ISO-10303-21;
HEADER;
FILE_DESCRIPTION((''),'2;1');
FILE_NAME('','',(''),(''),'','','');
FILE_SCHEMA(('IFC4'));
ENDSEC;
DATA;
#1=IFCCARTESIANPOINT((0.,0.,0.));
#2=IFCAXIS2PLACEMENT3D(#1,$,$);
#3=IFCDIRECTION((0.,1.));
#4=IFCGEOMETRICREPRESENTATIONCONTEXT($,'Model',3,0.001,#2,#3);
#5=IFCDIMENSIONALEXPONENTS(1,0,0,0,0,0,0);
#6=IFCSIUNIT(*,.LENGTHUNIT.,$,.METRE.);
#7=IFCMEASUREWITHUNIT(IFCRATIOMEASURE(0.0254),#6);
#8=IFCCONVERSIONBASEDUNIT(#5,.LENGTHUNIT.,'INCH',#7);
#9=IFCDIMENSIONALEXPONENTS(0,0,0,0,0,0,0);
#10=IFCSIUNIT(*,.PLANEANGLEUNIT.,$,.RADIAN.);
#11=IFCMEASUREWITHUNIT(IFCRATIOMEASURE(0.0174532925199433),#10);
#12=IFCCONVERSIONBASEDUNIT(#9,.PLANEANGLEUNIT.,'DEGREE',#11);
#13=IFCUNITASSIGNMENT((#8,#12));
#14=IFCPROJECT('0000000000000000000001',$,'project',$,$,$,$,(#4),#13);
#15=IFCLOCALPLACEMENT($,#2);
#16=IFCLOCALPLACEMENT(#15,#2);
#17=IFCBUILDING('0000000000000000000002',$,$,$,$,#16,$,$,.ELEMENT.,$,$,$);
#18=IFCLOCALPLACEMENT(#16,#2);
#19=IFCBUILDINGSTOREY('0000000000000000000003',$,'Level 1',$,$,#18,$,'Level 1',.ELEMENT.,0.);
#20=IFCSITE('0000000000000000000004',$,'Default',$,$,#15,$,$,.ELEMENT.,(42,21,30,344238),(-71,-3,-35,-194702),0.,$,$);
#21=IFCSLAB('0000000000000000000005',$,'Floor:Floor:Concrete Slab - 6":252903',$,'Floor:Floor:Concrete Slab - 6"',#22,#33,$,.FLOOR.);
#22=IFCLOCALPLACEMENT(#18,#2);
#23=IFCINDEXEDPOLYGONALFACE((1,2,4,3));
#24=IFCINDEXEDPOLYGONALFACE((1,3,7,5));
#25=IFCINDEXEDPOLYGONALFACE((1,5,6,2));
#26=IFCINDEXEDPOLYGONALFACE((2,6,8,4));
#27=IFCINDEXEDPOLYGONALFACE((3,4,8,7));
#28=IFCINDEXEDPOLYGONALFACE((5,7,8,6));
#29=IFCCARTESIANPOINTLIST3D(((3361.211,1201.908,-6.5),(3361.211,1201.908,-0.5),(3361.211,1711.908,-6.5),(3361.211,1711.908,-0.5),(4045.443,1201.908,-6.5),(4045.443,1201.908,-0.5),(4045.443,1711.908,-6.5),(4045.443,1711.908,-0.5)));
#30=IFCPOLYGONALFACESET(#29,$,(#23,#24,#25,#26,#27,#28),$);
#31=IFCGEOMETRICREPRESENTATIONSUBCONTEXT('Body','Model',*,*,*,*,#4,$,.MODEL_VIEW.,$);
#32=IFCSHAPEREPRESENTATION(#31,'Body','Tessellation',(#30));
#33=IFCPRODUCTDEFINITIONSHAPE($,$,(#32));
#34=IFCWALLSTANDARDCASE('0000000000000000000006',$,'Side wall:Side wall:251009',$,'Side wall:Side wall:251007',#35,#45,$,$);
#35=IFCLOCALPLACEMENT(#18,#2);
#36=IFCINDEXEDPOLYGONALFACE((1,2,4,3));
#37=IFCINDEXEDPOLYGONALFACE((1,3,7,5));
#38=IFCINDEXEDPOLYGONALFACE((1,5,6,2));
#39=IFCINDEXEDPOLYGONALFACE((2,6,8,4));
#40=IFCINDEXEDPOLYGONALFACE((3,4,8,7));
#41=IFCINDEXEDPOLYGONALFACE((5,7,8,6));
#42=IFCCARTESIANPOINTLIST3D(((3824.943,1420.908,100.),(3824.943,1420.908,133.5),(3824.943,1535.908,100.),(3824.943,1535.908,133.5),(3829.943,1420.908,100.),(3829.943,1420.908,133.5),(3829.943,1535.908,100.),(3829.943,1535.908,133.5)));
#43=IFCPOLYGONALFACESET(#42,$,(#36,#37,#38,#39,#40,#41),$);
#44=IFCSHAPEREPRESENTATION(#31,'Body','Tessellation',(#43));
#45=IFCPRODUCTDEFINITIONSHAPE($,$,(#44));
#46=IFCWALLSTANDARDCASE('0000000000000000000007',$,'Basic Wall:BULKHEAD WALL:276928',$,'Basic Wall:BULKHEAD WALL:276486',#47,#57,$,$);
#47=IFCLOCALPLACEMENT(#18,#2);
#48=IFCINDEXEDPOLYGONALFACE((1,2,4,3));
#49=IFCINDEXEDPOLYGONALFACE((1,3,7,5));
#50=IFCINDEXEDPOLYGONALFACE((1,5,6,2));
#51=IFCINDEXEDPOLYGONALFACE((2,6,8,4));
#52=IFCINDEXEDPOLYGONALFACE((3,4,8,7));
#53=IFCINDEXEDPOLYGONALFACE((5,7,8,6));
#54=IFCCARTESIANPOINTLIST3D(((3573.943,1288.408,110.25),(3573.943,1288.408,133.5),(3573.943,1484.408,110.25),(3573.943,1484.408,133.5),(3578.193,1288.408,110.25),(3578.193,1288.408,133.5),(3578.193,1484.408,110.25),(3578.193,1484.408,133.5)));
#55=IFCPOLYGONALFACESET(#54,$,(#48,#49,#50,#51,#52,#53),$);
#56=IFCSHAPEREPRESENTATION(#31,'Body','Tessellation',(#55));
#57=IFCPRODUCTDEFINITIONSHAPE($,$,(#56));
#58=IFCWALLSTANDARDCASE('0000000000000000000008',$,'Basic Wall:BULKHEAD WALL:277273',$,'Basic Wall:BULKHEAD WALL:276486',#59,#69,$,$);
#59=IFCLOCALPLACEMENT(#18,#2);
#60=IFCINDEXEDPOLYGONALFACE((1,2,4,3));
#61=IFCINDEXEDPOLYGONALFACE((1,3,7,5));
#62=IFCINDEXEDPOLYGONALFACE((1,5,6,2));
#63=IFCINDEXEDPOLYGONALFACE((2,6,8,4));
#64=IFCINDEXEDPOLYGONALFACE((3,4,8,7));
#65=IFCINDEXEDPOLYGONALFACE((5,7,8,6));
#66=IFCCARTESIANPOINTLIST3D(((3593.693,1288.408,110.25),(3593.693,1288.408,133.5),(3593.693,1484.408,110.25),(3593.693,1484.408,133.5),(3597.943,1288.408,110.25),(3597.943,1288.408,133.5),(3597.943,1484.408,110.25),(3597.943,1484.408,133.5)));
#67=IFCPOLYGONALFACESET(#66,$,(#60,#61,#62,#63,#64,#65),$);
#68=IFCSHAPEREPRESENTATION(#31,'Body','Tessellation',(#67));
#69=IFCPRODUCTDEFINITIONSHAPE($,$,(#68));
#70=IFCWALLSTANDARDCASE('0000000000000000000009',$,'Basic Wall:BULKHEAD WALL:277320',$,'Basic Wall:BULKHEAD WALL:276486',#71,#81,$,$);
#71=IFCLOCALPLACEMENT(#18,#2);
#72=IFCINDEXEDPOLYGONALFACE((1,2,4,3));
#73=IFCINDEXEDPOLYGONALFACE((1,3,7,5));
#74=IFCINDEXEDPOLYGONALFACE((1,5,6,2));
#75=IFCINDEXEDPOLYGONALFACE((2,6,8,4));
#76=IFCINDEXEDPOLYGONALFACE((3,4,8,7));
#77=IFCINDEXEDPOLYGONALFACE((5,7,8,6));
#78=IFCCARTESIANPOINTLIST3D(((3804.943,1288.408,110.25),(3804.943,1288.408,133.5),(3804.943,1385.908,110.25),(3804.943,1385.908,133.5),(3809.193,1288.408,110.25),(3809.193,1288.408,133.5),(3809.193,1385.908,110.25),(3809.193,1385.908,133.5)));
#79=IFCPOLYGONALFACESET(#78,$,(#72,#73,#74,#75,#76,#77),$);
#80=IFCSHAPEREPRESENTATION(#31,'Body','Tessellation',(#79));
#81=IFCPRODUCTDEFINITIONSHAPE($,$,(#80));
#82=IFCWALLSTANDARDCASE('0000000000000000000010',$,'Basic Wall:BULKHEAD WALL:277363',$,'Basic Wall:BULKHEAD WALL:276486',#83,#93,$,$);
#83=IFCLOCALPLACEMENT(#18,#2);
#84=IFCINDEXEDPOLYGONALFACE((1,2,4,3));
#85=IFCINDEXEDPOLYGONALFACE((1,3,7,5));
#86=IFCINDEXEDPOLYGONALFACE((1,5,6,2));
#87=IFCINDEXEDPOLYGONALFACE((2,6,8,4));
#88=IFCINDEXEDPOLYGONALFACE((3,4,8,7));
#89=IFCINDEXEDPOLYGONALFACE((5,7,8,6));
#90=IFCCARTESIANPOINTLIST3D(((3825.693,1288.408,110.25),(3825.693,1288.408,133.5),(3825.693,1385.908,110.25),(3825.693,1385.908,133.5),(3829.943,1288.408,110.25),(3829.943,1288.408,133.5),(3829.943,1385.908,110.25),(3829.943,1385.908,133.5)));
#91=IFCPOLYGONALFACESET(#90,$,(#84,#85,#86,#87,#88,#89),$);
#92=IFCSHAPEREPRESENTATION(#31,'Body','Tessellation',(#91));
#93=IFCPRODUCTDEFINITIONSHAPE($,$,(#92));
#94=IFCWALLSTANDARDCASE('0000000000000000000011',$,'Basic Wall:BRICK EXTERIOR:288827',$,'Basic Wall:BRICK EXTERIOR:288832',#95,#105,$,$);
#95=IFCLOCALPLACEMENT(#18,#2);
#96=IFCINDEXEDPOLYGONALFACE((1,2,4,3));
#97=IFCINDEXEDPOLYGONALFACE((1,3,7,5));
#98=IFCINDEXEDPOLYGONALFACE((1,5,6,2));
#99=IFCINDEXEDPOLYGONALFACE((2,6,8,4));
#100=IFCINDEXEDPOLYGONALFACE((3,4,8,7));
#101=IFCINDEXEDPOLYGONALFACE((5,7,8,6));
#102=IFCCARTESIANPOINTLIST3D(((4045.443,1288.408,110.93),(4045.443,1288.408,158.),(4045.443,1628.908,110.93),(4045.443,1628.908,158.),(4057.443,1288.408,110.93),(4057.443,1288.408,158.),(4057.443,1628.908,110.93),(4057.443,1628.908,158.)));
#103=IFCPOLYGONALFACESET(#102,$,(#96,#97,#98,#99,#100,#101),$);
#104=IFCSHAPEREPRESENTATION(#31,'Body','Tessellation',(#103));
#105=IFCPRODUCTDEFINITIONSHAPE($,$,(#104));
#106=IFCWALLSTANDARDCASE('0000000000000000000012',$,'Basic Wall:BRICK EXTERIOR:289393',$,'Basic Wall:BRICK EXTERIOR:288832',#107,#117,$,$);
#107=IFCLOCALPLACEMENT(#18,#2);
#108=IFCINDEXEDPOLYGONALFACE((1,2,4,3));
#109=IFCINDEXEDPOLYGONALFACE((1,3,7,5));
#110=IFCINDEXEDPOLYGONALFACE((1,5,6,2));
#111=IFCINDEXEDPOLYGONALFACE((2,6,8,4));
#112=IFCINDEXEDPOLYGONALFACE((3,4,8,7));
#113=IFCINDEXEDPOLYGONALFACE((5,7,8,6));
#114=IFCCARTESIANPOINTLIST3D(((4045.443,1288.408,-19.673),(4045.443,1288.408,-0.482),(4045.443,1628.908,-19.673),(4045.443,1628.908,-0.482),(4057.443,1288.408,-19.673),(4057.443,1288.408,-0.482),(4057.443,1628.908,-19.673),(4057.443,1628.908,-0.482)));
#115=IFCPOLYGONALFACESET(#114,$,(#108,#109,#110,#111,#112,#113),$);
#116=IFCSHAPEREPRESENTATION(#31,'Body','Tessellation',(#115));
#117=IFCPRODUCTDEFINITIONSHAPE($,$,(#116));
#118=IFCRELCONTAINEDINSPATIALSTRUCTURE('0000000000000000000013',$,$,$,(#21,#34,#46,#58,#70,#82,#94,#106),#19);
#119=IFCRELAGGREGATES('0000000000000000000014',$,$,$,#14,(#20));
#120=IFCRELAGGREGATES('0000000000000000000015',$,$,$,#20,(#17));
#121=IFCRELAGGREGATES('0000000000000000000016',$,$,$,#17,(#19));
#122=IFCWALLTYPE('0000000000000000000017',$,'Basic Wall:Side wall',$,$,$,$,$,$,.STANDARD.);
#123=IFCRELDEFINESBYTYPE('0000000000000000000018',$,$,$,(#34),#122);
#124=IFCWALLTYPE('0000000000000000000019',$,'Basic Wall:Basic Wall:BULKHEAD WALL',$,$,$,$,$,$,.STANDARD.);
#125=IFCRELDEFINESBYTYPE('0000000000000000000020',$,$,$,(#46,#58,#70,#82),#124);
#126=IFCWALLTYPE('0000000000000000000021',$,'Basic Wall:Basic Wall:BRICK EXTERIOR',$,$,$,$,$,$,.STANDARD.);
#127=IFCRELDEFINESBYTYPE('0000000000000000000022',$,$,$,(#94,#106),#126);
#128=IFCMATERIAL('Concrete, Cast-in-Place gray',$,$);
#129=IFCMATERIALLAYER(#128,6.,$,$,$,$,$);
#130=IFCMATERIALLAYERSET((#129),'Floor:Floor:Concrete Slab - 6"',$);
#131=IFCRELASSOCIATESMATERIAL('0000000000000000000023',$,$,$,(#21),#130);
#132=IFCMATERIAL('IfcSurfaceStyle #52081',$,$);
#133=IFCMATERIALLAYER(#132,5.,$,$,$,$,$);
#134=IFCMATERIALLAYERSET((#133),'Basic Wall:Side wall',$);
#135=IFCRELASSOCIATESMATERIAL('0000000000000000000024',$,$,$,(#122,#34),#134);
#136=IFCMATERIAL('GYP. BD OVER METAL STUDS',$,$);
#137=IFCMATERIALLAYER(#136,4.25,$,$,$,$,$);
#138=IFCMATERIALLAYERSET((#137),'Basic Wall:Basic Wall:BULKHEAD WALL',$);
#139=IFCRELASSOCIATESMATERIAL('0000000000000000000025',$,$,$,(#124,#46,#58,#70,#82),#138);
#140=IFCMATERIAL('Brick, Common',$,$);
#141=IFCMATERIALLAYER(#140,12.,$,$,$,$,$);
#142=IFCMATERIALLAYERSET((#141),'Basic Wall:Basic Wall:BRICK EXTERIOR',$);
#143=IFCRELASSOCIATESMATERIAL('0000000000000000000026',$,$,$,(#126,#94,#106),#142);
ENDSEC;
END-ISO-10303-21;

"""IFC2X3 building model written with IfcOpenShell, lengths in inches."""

from ifc_helpers import new_model, entity, si_unit, converted_unit, direction, frame, frame_2d, origin, place, context, subcontext, project, spatial, rectangle, extrude, material, layer, layer_set, layer_usage, type_object, element, save


model = new_model("IFC2X3")

# Units and contexts
model_context = context("Model", 3, precision=0.001, world=origin(), true_north=direction((0.0, 1.0)))
body_context = subcontext(model_context, "Body", "Model", "MODEL_VIEW")
ifc_project = project(units=[converted_unit("LENGTHUNIT", "INCH", entity("IfcRatioMeasure", 0.0254), si_unit("LENGTHUNIT", "METRE"), dimensions=[1, 0, 0, 0, 0, 0, 0]), converted_unit("PLANEANGLEUNIT", "DEGREE", entity("IfcRatioMeasure", 0.0174532925199433), si_unit("PLANEANGLEUNIT", "RADIAN"), dimensions=[0, 0, 0, 0, 0, 0, 0])], contexts=[model_context])

# Site, building, storey
site_placement = place(None, origin())
site = spatial("IfcSite", under=ifc_project, at=site_placement, Name="Default", CompositionType="ELEMENT", RefLatitude=(42, 21, 30, 344238), RefLongitude=(-71, -3, -35, -194702), RefElevation=0.0)
building_placement = place(site_placement, origin())
building = spatial("IfcBuilding", under=site, at=building_placement, CompositionType="ELEMENT")
storey_placement = place(building_placement, origin())
storey = spatial("IfcBuildingStorey", under=building, at=storey_placement, Name="Level 1", LongName="Level 1", CompositionType="ELEMENT", Elevation=0.0)

# Slab
ifc_material_1 = material(Name="Concrete, Cast-in-Place gray")
ifc_layer_1 = layer(ifc_material_1, 6.0)
ifc_layer_set_1 = layer_set([ifc_layer_1], Name="Floor:Floor:Concrete Slab - 6\"")
ifc_layer_usage_1 = layer_usage(ifc_layer_set_1, "AXIS3", "POSITIVE", 0.0)
slab_placement = place(storey_placement, origin())
element("IfcSlab", 1, at=slab_placement, inside=storey, material=ifc_layer_usage_1, Name="Floor:Floor:Concrete Slab - 6\":252903", ObjectType="Floor:Floor:Concrete Slab - 6\"", PredefinedType="FLOOR", context=body_context, shape_type="SweptSolid", body=[
    extrude(rectangle(XDim=510.0, YDim=684.232, at=frame_2d((0.0, 0.0), x_axis=(1.0, 0.0))), frame((3703.327, 1456.908, -0.5), z_axis=(0.0, 0.0, -1.0), x_axis=(0.0, 1.0, 0.0)), (0.0, 0.0, 1.0), 6.0),
])

# Walls
ifc_material_2 = material(Name="IfcSurfaceStyle #52081")
ifc_layer_2 = layer(ifc_material_2, 5.0)
ifc_layer_set_2 = layer_set([ifc_layer_2], Name="Basic Wall:Side wall")
ifc_layer_usage_2 = layer_usage(ifc_layer_set_2, "AXIS2", "NEGATIVE", 2.5)
wall_type_1 = type_object("IfcWallType", Name="Basic Wall:Side wall", PredefinedType="STANDARD", material=ifc_layer_set_2)
wall_1_placement = place(storey_placement, frame((3827.443, 1535.908, 100.0), z_axis=(0.0, 0.0, 1.0), x_axis=(0.0, -1.0, 0.0)))
element("IfcWallStandardCase", 2, at=wall_1_placement, inside=storey, type_object=wall_type_1, material=ifc_layer_usage_2, Name="Side wall:Side wall:251009", ObjectType="Side wall:Side wall:251007", context=body_context, shape_type="SweptSolid", body=[
    extrude(rectangle(XDim=115.0, YDim=5.0, at=frame_2d((57.5, 0.0), x_axis=(-1.0, 0.0))), origin(), (0.0, 0.0, 1.0), 33.5),
])
ifc_material_3 = material(Name="GYP. BD OVER METAL STUDS")
ifc_layer_3 = layer(ifc_material_3, 4.25)
ifc_layer_set_3 = layer_set([ifc_layer_3], Name="Basic Wall:Basic Wall:BULKHEAD WALL")
ifc_layer_usage_3 = layer_usage(ifc_layer_set_3, "AXIS2", "NEGATIVE", 2.125)
wall_type_2 = type_object("IfcWallType", Name="Basic Wall:Basic Wall:BULKHEAD WALL", PredefinedType="STANDARD", material=ifc_layer_set_3)
wall_2_placement = place(storey_placement, frame((3576.068, 1288.408, 110.25), z_axis=(0.0, 0.0, 1.0), x_axis=(0.0, 1.0, 0.0)))
element("IfcWallStandardCase", 3, at=wall_2_placement, inside=storey, type_object=wall_type_2, material=ifc_layer_usage_3, Name="Basic Wall:BULKHEAD WALL:276928", ObjectType="Basic Wall:BULKHEAD WALL:276486", context=body_context, shape_type="SweptSolid", body=[
    extrude(rectangle(XDim=196.0, YDim=4.25, at=frame_2d((98.0, 0.0), x_axis=(-1.0, 0.0))), origin(), (0.0, 0.0, 1.0), 23.25),
])
ifc_layer_usage_4 = layer_usage(ifc_layer_set_3, "AXIS2", "NEGATIVE", 2.125)
wall_3_placement = place(storey_placement, frame((3595.818, 1484.408, 110.25), z_axis=(0.0, 0.0, 1.0), x_axis=(0.0, -1.0, 0.0)))
element("IfcWallStandardCase", 4, at=wall_3_placement, inside=storey, type_object=wall_type_2, material=ifc_layer_usage_4, Name="Basic Wall:BULKHEAD WALL:277273", ObjectType="Basic Wall:BULKHEAD WALL:276486", context=body_context, shape_type="SweptSolid", body=[
    extrude(rectangle(XDim=196.0, YDim=4.25, at=frame_2d((98.0, 0.0), x_axis=(-1.0, 0.0))), origin(), (0.0, 0.0, 1.0), 23.25),
])
ifc_layer_usage_5 = layer_usage(ifc_layer_set_3, "AXIS2", "NEGATIVE", 2.125)
wall_4_placement = place(storey_placement, frame((3807.068, 1288.408, 110.25), z_axis=(0.0, 0.0, 1.0), x_axis=(0.0, 1.0, 0.0)))
element("IfcWallStandardCase", 5, at=wall_4_placement, inside=storey, type_object=wall_type_2, material=ifc_layer_usage_5, Name="Basic Wall:BULKHEAD WALL:277320", ObjectType="Basic Wall:BULKHEAD WALL:276486", context=body_context, shape_type="SweptSolid", body=[
    extrude(rectangle(XDim=97.5, YDim=4.25, at=frame_2d((48.75, 0.0), x_axis=(-1.0, 0.0))), origin(), (0.0, 0.0, 1.0), 23.25),
])
ifc_layer_usage_6 = layer_usage(ifc_layer_set_3, "AXIS2", "NEGATIVE", 2.125)
wall_5_placement = place(storey_placement, frame((3827.818, 1385.908, 110.25), z_axis=(0.0, 0.0, 1.0), x_axis=(0.0, -1.0, 0.0)))
element("IfcWallStandardCase", 6, at=wall_5_placement, inside=storey, type_object=wall_type_2, material=ifc_layer_usage_6, Name="Basic Wall:BULKHEAD WALL:277363", ObjectType="Basic Wall:BULKHEAD WALL:276486", context=body_context, shape_type="SweptSolid", body=[
    extrude(rectangle(XDim=97.5, YDim=4.25, at=frame_2d((48.75, 0.0), x_axis=(-1.0, 0.0))), origin(), (0.0, 0.0, 1.0), 23.25),
])
ifc_material_4 = material(Name="Brick, Common")
ifc_layer_4 = layer(ifc_material_4, 12.0)
ifc_layer_set_4 = layer_set([ifc_layer_4], Name="Basic Wall:Basic Wall:BRICK EXTERIOR")
ifc_layer_usage_7 = layer_usage(ifc_layer_set_4, "AXIS2", "NEGATIVE", 6.0)
wall_type_3 = type_object("IfcWallType", Name="Basic Wall:Basic Wall:BRICK EXTERIOR", PredefinedType="STANDARD", material=ifc_layer_set_4)
wall_6_placement = place(storey_placement, frame((4051.443, 1628.908, 110.93), z_axis=(0.0, 0.0, 1.0), x_axis=(0.0, -1.0, 0.0)))
element("IfcWallStandardCase", 7, at=wall_6_placement, inside=storey, type_object=wall_type_3, material=ifc_layer_usage_7, Name="Basic Wall:BRICK EXTERIOR:288827", ObjectType="Basic Wall:BRICK EXTERIOR:288832", context=body_context, shape_type="SweptSolid", body=[
    extrude(rectangle(XDim=340.5, YDim=12.0, at=frame_2d((170.25, 0.0), x_axis=(-1.0, 0.0))), origin(), (0.0, 0.0, 1.0), 47.07),
])
ifc_layer_usage_8 = layer_usage(ifc_layer_set_4, "AXIS2", "NEGATIVE", 6.0)
wall_7_placement = place(storey_placement, frame((4051.443, 1628.908, -19.673), z_axis=(0.0, 0.0, 1.0), x_axis=(0.0, -1.0, 0.0)))
element("IfcWallStandardCase", 8, at=wall_7_placement, inside=storey, type_object=wall_type_3, material=ifc_layer_usage_8, Name="Basic Wall:BRICK EXTERIOR:289393", ObjectType="Basic Wall:BRICK EXTERIOR:288832", context=body_context, shape_type="SweptSolid", body=[
    extrude(rectangle(XDim=340.5, YDim=12.0, at=frame_2d((170.25, 0.0), x_axis=(-1.0, 0.0))), origin(), (0.0, 0.0, 1.0), 19.192),
])

save(model, "model.ifc")
